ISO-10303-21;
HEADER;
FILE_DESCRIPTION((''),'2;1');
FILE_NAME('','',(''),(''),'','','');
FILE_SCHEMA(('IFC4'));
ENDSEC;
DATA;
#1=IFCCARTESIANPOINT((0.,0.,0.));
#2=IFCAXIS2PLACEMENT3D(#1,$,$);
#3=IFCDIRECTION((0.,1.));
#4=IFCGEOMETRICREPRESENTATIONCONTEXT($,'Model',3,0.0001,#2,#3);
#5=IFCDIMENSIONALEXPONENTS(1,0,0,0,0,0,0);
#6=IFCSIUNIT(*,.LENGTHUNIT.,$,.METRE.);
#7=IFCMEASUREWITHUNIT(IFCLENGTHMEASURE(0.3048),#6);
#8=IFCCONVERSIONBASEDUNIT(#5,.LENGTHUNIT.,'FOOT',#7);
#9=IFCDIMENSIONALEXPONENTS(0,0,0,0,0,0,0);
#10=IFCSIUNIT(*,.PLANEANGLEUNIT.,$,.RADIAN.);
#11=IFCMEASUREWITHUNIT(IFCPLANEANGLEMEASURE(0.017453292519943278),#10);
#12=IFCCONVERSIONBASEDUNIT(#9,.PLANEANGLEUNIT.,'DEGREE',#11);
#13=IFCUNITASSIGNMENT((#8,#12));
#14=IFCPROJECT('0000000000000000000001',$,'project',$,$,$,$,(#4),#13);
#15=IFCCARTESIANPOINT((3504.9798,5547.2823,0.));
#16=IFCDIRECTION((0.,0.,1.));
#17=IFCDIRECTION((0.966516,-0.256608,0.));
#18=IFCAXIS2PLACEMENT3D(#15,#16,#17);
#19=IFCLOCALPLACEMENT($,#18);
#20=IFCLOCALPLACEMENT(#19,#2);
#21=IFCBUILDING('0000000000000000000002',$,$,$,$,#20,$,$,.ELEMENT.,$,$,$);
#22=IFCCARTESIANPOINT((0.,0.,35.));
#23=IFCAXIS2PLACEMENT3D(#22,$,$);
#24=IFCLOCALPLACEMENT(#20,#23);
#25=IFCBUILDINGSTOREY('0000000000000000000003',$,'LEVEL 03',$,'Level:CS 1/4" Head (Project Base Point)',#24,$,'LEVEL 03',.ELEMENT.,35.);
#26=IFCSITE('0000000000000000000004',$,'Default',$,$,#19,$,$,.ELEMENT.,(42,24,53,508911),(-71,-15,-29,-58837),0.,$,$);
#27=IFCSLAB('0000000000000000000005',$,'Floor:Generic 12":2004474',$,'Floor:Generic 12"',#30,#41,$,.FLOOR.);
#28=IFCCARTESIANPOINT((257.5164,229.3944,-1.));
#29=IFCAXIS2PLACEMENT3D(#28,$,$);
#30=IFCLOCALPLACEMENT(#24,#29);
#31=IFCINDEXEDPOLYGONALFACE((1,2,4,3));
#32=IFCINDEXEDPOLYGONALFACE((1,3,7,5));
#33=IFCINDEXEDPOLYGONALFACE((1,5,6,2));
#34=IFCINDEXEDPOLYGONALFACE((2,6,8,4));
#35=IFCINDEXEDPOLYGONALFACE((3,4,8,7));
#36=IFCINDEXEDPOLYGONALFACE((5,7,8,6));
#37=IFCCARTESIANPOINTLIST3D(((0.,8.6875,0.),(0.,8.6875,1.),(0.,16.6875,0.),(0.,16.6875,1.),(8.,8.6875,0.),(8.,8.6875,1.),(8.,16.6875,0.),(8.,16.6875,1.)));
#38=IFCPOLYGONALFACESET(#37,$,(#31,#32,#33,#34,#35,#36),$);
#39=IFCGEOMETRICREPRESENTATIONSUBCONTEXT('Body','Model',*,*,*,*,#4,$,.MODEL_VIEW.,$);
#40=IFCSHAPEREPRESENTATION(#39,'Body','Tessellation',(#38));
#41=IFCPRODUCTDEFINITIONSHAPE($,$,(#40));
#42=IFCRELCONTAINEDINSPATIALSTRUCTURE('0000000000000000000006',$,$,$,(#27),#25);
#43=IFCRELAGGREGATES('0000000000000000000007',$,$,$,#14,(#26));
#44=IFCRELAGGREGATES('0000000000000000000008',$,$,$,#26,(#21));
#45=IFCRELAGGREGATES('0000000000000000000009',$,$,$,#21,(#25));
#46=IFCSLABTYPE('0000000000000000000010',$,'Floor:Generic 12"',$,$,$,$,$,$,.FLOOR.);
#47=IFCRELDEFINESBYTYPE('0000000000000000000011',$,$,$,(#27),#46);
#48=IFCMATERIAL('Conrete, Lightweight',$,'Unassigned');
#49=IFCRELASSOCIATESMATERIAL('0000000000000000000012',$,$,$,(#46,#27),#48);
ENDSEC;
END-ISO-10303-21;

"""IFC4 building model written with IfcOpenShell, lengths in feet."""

from ifc_helpers import new_model, entity, si_unit, converted_unit, direction, frame, origin, origin_2d_with_axis, place, context, subcontext, project, spatial, rectangle, extrude, material, type_object, element, save


model = new_model("IFC4")

# Units and contexts
model_context = context("Model", 3, precision=0.0001, world=origin(), true_north=direction((0.0, 1.0)))
body_context = subcontext(model_context, "Body", "Model", "MODEL_VIEW")
ifc_project = project(units=[converted_unit("LENGTHUNIT", "FOOT", entity("IfcLengthMeasure", 0.3048), si_unit("LENGTHUNIT", "METRE"), dimensions=[1, 0, 0, 0, 0, 0, 0]), converted_unit("PLANEANGLEUNIT", "DEGREE", entity("IfcPlaneAngleMeasure", 0.017453292519943278), si_unit("PLANEANGLEUNIT", "RADIAN"), dimensions=[0, 0, 0, 0, 0, 0, 0])], contexts=[model_context])

# Site, building, storey
site_placement = place(None, frame((3504.9798, 5547.2823, 0.0), z_axis=(0.0, 0.0, 1.0), x_axis=(0.966516, -0.256608, 0.0)))
site = spatial("IfcSite", under=ifc_project, at=site_placement, Name="Default", CompositionType="ELEMENT", RefLatitude=(42, 24, 53, 508911), RefLongitude=(-71, -15, -29, -58837), RefElevation=0.0)
building_placement = place(site_placement, origin())
building = spatial("IfcBuilding", under=site, at=building_placement, CompositionType="ELEMENT")
storey_placement = place(building_placement, frame((0.0, 0.0, 35.0)))
storey = spatial("IfcBuildingStorey", under=building, at=storey_placement, Name="LEVEL 03", ObjectType="Level:CS 1/4\" Head (Project Base Point)", LongName="LEVEL 03", CompositionType="ELEMENT", Elevation=35.0)

# Shared definitions
ifc_material_1 = material(Name="Conrete, Lightweight", Category="Unassigned")
slab_type = type_object("IfcSlabType", Name="Floor:Generic 12\"", PredefinedType="FLOOR", material=ifc_material_1)

# Slab
slab_1_placement = place(storey_placement, frame((257.5164, 229.3944, -1.0)))
element("IfcSlab", 1, at=slab_1_placement, inside=storey, type_object=slab_type, material=ifc_material_1, Name="Floor:Generic 12\":2004474", ObjectType="Floor:Generic 12\"", PredefinedType="FLOOR", context=body_context, shape_type="SweptSolid", body=[
    extrude(rectangle(XDim=8.0, YDim=8.0, at=origin_2d_with_axis()), frame((4.0, 12.6875, 1.0), z_axis=(0.0, 0.0, -1.0), x_axis=(-1.0, 0.0, 0.0)), (0.0, 0.0, 1.0), 1.0),
])

save(model, "model.ifc")
